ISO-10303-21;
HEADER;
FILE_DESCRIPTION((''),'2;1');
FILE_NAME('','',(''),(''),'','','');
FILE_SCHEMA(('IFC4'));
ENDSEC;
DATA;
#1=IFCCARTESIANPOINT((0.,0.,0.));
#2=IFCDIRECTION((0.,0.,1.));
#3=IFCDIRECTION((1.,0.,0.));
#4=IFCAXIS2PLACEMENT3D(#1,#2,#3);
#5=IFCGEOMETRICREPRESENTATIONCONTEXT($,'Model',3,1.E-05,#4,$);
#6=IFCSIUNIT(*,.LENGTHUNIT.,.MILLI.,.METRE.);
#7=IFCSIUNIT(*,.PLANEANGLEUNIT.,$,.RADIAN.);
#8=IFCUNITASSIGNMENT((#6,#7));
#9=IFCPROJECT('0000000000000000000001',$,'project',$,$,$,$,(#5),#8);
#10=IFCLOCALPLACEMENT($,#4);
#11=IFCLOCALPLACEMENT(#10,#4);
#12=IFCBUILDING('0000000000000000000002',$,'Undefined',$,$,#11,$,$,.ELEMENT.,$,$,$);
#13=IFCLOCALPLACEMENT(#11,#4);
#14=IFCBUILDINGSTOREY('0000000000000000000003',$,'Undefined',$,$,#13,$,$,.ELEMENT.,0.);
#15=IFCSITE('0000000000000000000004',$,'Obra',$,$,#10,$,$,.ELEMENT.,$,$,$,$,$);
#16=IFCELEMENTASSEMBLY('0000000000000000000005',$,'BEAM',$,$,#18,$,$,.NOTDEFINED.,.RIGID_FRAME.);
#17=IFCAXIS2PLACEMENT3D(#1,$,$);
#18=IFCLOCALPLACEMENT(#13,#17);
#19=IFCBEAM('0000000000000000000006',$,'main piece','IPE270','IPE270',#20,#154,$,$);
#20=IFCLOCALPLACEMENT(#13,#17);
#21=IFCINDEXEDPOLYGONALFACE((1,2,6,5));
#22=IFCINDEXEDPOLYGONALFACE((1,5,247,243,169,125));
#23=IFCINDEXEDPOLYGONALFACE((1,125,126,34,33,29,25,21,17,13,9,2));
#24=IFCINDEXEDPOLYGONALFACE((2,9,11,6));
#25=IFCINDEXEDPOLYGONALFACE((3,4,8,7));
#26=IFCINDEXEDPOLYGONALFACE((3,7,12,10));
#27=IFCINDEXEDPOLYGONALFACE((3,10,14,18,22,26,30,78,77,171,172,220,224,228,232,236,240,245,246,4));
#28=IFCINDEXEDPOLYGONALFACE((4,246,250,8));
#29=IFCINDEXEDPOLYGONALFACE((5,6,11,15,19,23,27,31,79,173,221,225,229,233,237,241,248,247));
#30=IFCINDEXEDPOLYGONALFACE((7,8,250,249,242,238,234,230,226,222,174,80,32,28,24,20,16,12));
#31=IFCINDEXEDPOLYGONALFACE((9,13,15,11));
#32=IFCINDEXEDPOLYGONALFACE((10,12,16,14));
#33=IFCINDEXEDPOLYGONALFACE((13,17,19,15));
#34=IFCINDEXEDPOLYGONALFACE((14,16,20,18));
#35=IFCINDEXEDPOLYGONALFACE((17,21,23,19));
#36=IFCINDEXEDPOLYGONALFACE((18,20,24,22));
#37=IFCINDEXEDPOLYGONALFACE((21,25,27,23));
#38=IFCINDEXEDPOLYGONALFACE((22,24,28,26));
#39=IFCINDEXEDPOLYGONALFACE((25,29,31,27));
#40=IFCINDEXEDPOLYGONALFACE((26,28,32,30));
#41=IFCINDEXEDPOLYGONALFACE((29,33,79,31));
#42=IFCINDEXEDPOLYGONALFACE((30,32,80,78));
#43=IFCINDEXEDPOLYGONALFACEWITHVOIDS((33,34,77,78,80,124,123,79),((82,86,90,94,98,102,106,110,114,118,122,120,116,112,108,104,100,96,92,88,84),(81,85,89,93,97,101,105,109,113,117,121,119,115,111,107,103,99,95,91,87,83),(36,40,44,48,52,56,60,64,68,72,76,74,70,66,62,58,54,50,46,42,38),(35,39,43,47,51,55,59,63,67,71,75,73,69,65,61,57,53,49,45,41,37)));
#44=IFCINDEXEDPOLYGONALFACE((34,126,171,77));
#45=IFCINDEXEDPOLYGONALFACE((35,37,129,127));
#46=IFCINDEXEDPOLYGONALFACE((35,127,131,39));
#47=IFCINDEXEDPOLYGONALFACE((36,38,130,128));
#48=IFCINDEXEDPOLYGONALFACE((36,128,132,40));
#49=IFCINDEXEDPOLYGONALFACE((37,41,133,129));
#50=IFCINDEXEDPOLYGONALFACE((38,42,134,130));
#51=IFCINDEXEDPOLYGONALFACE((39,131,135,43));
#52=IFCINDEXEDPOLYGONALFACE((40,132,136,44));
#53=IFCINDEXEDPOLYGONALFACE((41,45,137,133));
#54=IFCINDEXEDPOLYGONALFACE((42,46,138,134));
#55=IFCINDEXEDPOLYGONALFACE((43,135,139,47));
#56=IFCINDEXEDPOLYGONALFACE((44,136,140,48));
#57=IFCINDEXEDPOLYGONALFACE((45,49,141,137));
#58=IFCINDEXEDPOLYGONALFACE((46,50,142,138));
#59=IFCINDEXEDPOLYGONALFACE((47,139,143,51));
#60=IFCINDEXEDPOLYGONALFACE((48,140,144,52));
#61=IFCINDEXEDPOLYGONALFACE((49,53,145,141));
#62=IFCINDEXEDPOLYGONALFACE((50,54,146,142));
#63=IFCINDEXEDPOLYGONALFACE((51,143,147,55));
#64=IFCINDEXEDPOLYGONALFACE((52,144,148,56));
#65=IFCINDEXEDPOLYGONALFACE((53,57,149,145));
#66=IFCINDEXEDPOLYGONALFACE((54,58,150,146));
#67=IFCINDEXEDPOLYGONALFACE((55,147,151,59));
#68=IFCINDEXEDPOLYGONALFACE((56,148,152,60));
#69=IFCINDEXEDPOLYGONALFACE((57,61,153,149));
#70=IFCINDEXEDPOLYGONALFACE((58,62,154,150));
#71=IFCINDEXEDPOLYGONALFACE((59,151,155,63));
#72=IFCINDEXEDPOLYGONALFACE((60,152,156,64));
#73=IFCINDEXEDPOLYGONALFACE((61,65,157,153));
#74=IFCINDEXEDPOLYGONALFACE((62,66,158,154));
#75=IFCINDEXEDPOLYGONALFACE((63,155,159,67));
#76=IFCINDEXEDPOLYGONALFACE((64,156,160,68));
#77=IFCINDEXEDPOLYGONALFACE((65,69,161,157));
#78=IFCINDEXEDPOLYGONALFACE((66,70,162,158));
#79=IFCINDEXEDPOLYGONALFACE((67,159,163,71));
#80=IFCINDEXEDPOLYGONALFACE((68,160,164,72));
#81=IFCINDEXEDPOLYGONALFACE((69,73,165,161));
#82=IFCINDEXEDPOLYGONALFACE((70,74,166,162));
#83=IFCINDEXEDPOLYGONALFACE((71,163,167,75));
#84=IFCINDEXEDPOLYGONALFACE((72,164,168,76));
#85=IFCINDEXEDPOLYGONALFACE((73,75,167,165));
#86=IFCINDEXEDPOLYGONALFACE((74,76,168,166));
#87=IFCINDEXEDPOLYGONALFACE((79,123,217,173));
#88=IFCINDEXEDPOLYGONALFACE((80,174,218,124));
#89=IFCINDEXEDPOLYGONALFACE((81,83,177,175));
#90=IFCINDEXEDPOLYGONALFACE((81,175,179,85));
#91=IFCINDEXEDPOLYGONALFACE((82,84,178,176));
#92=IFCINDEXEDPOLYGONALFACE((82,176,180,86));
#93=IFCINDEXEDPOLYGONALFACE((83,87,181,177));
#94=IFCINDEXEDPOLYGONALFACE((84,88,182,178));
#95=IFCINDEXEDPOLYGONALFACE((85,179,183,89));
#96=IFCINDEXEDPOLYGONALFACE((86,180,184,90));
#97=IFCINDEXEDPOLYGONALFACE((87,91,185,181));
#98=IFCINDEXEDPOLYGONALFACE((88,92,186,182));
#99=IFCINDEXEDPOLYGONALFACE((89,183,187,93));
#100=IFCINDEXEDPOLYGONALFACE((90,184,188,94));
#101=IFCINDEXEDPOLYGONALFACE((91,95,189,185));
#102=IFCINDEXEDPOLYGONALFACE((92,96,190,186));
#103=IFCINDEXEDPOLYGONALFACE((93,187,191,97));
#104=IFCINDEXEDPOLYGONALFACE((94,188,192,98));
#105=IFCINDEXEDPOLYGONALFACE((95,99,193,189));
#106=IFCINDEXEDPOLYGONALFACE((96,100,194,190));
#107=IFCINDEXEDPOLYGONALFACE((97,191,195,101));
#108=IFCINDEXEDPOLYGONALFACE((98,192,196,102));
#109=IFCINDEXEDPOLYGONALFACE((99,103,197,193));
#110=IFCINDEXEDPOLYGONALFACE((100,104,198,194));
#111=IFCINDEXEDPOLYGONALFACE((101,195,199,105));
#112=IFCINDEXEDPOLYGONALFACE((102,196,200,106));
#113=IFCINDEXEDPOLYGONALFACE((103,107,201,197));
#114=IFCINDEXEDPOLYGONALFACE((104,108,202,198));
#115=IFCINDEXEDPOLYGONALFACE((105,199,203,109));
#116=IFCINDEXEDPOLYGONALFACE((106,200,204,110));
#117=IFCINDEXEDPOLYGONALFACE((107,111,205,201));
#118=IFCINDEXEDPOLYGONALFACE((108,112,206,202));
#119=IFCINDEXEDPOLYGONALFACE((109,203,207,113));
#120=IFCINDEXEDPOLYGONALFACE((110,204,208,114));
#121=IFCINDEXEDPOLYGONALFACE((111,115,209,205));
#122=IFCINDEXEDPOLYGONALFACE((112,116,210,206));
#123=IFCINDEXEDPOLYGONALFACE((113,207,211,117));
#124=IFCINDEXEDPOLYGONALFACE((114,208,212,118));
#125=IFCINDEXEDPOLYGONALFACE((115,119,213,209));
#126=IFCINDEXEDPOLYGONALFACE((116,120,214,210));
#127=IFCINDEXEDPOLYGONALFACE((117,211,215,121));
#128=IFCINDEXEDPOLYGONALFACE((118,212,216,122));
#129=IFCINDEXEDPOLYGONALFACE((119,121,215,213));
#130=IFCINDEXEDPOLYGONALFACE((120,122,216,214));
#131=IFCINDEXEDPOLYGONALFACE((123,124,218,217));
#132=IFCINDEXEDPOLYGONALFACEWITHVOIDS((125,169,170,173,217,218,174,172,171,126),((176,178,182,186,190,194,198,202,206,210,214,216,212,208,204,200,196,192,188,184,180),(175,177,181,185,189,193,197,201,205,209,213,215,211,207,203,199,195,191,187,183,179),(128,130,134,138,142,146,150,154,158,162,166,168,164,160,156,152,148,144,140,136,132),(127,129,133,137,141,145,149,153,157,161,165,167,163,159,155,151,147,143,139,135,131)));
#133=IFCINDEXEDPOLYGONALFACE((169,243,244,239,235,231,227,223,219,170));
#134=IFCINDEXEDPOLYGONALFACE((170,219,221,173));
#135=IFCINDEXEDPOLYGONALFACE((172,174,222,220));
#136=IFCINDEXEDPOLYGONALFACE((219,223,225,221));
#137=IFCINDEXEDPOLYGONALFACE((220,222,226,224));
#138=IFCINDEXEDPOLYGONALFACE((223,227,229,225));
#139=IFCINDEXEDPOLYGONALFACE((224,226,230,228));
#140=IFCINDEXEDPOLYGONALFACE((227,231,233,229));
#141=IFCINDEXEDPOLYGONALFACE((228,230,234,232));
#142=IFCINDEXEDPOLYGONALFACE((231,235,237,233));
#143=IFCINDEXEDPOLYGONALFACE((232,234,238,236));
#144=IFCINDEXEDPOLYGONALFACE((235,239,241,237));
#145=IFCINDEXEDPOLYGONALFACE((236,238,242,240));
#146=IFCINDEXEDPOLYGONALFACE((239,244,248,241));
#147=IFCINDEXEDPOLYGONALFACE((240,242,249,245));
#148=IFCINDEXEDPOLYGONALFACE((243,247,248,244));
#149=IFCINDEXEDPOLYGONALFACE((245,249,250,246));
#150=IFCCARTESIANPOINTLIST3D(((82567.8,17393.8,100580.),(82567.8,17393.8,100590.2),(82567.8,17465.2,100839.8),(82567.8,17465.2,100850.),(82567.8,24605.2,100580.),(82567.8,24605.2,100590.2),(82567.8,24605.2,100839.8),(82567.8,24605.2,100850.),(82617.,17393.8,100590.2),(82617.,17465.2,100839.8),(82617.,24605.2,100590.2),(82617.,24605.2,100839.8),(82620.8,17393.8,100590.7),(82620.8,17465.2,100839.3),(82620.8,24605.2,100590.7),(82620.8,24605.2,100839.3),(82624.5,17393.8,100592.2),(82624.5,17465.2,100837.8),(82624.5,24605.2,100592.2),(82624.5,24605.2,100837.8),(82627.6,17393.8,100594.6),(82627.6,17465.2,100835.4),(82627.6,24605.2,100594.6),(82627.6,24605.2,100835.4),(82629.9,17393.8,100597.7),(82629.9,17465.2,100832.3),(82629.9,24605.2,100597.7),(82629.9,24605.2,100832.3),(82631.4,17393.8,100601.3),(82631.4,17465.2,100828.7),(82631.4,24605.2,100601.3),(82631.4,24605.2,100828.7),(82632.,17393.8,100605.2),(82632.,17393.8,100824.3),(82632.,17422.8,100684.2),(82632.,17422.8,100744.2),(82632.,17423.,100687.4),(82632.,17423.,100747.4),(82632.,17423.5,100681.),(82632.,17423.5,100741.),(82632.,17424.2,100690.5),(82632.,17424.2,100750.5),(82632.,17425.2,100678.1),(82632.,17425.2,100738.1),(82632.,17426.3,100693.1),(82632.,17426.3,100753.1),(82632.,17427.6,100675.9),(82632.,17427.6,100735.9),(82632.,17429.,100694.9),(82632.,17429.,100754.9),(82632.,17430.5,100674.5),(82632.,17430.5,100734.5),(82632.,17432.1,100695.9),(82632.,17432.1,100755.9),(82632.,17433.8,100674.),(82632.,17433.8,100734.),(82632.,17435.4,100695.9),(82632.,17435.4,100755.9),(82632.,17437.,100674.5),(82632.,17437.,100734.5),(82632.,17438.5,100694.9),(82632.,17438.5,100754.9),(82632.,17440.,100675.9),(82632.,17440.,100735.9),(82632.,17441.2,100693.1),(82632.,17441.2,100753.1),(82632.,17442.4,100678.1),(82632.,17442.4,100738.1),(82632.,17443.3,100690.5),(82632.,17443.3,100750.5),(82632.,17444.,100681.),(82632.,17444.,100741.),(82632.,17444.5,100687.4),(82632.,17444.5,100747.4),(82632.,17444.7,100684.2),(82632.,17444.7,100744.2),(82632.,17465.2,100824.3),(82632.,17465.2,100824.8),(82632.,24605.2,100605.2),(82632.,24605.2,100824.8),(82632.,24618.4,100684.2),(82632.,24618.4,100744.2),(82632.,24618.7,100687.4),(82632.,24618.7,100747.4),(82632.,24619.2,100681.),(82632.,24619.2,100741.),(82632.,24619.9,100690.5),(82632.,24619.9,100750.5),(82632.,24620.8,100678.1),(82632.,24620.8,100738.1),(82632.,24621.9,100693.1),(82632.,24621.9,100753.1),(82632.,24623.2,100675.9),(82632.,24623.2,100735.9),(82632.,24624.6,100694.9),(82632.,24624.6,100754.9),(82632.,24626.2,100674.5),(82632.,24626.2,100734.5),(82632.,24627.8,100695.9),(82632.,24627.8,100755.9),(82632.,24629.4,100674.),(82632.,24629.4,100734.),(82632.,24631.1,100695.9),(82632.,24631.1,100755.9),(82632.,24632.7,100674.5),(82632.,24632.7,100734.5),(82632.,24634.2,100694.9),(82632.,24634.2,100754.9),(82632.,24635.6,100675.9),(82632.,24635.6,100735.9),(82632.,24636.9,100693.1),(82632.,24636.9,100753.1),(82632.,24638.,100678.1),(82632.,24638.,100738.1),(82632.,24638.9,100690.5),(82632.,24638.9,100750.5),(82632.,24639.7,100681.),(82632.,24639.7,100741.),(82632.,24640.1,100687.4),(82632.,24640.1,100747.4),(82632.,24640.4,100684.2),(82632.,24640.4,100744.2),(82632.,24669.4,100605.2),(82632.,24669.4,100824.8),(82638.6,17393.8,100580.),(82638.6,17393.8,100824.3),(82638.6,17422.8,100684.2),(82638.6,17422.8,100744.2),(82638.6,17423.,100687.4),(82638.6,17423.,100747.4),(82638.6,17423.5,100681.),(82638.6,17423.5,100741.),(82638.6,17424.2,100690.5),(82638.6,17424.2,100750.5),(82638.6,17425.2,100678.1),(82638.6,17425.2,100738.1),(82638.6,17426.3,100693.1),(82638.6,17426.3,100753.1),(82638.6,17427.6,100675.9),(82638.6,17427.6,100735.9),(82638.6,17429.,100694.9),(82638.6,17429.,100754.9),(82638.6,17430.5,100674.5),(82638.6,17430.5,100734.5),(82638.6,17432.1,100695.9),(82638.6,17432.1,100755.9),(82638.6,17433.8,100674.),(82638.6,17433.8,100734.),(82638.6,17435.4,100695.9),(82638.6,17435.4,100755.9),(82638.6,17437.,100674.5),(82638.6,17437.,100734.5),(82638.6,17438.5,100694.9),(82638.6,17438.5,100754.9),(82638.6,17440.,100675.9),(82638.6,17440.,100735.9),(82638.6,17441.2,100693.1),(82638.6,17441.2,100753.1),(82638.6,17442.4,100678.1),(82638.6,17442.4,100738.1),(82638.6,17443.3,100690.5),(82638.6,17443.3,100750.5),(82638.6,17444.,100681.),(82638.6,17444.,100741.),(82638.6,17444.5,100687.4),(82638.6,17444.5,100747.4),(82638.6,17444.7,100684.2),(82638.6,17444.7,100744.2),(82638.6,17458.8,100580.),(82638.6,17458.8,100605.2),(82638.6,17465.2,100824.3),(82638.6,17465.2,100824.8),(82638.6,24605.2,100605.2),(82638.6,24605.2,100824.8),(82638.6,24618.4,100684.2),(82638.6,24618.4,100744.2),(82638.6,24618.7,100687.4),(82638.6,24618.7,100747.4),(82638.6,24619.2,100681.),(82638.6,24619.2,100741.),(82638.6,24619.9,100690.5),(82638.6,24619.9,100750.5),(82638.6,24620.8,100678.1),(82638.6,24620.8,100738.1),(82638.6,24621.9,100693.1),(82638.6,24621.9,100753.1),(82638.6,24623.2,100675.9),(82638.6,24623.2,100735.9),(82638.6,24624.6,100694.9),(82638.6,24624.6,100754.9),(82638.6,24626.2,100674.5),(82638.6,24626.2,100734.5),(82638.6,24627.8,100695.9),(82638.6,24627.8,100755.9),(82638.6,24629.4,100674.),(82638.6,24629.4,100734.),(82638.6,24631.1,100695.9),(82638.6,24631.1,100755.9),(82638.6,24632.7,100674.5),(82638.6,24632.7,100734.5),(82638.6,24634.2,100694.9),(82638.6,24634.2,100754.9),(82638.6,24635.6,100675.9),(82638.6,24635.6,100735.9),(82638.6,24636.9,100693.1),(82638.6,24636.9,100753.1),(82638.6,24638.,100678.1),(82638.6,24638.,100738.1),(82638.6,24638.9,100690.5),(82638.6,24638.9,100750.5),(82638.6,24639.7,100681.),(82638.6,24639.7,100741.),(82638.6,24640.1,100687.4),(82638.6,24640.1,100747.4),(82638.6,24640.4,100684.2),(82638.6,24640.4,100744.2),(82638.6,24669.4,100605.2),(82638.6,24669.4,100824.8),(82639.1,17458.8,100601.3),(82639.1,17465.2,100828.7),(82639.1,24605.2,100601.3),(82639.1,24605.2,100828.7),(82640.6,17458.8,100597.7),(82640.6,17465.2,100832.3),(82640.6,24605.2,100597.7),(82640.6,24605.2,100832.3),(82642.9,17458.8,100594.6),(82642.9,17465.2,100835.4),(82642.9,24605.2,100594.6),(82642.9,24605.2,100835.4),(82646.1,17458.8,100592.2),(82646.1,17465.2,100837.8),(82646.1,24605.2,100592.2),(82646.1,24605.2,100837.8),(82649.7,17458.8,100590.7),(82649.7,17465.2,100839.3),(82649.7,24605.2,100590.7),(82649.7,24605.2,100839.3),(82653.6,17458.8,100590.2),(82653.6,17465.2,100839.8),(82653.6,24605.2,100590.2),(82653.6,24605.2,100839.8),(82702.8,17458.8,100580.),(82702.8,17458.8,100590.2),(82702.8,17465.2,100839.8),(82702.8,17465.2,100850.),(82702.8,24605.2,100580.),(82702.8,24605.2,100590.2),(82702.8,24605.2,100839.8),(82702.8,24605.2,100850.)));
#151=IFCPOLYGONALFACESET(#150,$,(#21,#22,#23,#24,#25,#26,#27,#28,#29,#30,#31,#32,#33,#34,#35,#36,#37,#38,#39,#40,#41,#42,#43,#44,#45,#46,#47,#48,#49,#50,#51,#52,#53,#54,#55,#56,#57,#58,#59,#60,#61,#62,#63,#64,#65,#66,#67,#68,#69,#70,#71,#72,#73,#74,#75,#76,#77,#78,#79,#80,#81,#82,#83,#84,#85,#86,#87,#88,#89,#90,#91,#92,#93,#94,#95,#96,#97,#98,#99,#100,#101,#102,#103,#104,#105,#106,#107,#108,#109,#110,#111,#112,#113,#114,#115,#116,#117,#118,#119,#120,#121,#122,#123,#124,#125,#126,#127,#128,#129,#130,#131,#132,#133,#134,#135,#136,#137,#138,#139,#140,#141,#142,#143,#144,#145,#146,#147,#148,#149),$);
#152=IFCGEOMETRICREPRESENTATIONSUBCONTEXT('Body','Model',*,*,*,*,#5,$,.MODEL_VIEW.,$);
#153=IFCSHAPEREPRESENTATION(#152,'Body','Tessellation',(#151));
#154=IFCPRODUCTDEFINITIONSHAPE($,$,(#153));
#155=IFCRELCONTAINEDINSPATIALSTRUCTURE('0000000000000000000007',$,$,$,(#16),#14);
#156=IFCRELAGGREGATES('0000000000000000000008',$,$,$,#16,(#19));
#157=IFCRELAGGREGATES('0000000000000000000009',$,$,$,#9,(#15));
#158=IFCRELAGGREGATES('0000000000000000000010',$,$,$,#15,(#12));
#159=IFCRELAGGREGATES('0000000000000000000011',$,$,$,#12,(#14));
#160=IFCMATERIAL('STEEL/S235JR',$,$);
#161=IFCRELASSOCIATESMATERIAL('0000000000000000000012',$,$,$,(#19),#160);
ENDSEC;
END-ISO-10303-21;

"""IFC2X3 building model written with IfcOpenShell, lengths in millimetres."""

from ifc_helpers import new_model, si_unit, frame, origin_with_axes, origin_2d_with_axis, place, context, subcontext, project, spatial, rectangle, circle, i_section, extrude, clip, halfspace, source, transform, mapped, material, element, aggregate, save


model = new_model("IFC2X3")

# Units and contexts
model_context = context("Model", 3, precision=1e-05, world=origin_with_axes())
body_context = subcontext(model_context, "Body", "Model", "MODEL_VIEW")
ifc_project = project(units=[si_unit("LENGTHUNIT", "METRE", prefix="MILLI"), si_unit("PLANEANGLEUNIT", "RADIAN")], contexts=[model_context])

# Site, building, storey
site_placement = place(None, origin_with_axes())
site = spatial("IfcSite", under=ifc_project, at=site_placement, Name="Obra", CompositionType="ELEMENT")
building_placement = place(site_placement, origin_with_axes())
building = spatial("IfcBuilding", under=site, at=building_placement, Name="Undefined", CompositionType="ELEMENT")
storey_placement = place(building_placement, origin_with_axes())
storey = spatial("IfcBuildingStorey", under=building, at=storey_placement, Name="Undefined", CompositionType="ELEMENT", Elevation=0.0)

# Shared definitions
ifc_material = material(Name="STEEL/S235JR")

# Element assembly, beam, openings
assembly_1_placement = place(storey_placement, origin_with_axes())
assembly_1 = element("IfcElementAssembly", 1, at=assembly_1_placement, inside=storey, Name="BEAM", AssemblyPlace="NOTDEFINED", PredefinedType="RIGID_FRAME")
beam_1_placement = place(assembly_1_placement, frame((82635.3, 17482.5, 100715.0), z_axis=(0.0, 0.0, 1.0), x_axis=(0.0, 1.0, 0.0)))
beam_1 = element("IfcBeam", 2, at=beam_1_placement, material=ifc_material, Name="main piece", Description="IPE270", ObjectType="IPE270", context=body_context, shape_type="Clipping", body=[
    clip(clip(extrude(i_section(OverallWidth=135.0, OverallDepth=270.0, WebThickness=6.6, FlangeThickness=10.2, FilletRadius=15.0, at=origin_2d_with_axis()), frame((7186.9, 0.0, 0.0), z_axis=(-1.0, 0.0, 0.0), x_axis=(0.0, -1.0, 0.0)), (0.0, 0.0, 1.0), 7275.7), halfspace(frame((7186.9, 0.0, -235.0), z_axis=(-1.0, -0.000002, 0.0), x_axis=(-0.000002, 1.0, 0.0)), True)), halfspace(frame((-88.7, 0.0, -235.0), z_axis=(1.0, 0.0, 0.0), x_axis=(0.0, -1.0, 0.0)), True)),
])
opening_1_placement = place(assembly_1_placement, frame((82635.3, 17482.5, 100715.0), z_axis=(0.0, 0.0, 1.0), x_axis=(0.0, 1.0, 0.0)))
element("IfcOpeningElement", 3, at=opening_1_placement, cuts=beam_1, ObjectType="Recess", context=body_context, shape_type="SweptSolid", body=[
    extrude(rectangle(XDim=75.0, YDim=300.0, at=origin_2d_with_axis()), frame((-61.2, -153.3, 124.3), z_axis=(0.0, 0.0, -1.0), x_axis=(1.0, 0.0, 0.0)), (0.0, 0.0, 1.0), 278.6),
])
opening_2_placement = place(assembly_1_placement, frame((82635.3, 17482.5, 100715.0), z_axis=(0.0, 0.0, 1.0), x_axis=(0.0, 1.0, 0.0)))
element("IfcOpeningElement", 4, at=opening_2_placement, cuts=beam_1, ObjectType="Recess", context=body_context, shape_type="SweptSolid", body=[
    extrude(rectangle(XDim=26.7, YDim=83.5, at=origin_2d_with_axis()), frame((-59.0, -68.5, 122.7), z_axis=(0.0, 1.0, 0.0), x_axis=(0.0, 0.0, -1.0)), (0.0, 0.0, 1.0), 137.0),
])
opening_3_placement = place(assembly_1_placement, frame((82635.3, 17482.5, 100715.0), z_axis=(0.0, 0.0, 1.0), x_axis=(0.0, 1.0, 0.0)))
element("IfcOpeningElement", 5, at=opening_3_placement, cuts=beam_1, ObjectType="Recess", context=body_context, shape_type="SweptSolid", body=[
    extrude(rectangle(XDim=26.2, YDim=76.2, at=origin_2d_with_axis()), frame((7160.8, 68.5, -122.9), z_axis=(0.000002, -1.0, 0.0), x_axis=(0.0, 0.0, -1.0)), (0.0, 0.0, 1.0), 137.0),
])
opening_4_placement = place(assembly_1_placement, frame((82635.3, 17482.5, 100715.0), z_axis=(0.0, 0.0, 1.0), x_axis=(0.0, 1.0, 0.0)))
element("IfcOpeningElement", 6, at=opening_4_placement, cuts=beam_1, ObjectType="Recess", context=body_context, shape_type="SweptSolid", body=[
    extrude(rectangle(XDim=26.2, YDim=76.2, at=origin_2d_with_axis()), frame((7160.8, 68.5, 122.9), z_axis=(0.000002, -1.0, 0.0), x_axis=(0.0, 0.0, -1.0)), (0.0, 0.0, 1.0), 137.0),
])
shared_shape = source(origin_with_axes(), body_context, "Body", "SweptSolid", [
    extrude(circle(Radius=11.0, at=origin_2d_with_axis()), frame((0.0, -3.4, 0.0), z_axis=(0.0, 1.0, 0.0), x_axis=(1.0, 0.0, 0.0)), (0.0, 0.0, 1.0), 6.8),
])
opening_5_placement = place(assembly_1_placement, frame((82635.3, 17393.8, 100850.0), z_axis=(0.0, 1.0, 0.0), x_axis=(0.0, 0.0, -1.0)))
element("IfcOpeningElement", 7, at=opening_5_placement, cuts=beam_1, ObjectType="Opening", context=body_context, shape_type="MappedRepresentation", body=[
    mapped(shared_shape, transform((105.0, 0.0, 40.0))),
    mapped(shared_shape, transform((165.0, 0.0, 40.0))),
])
opening_6_placement = place(assembly_1_placement, frame((82635.3, 24669.4, 100850.0), z_axis=(0.000002, -1.0, 0.0), x_axis=(0.0, 0.0, -1.0)))
element("IfcOpeningElement", 8, at=opening_6_placement, cuts=beam_1, ObjectType="Opening", context=body_context, shape_type="MappedRepresentation", body=[
    mapped(shared_shape, transform((105.0, 0.0, 40.0))),
    mapped(shared_shape, transform((165.0, 0.0, 40.0))),
])
aggregate(assembly_1, [beam_1])

save(model, "model.ifc")
